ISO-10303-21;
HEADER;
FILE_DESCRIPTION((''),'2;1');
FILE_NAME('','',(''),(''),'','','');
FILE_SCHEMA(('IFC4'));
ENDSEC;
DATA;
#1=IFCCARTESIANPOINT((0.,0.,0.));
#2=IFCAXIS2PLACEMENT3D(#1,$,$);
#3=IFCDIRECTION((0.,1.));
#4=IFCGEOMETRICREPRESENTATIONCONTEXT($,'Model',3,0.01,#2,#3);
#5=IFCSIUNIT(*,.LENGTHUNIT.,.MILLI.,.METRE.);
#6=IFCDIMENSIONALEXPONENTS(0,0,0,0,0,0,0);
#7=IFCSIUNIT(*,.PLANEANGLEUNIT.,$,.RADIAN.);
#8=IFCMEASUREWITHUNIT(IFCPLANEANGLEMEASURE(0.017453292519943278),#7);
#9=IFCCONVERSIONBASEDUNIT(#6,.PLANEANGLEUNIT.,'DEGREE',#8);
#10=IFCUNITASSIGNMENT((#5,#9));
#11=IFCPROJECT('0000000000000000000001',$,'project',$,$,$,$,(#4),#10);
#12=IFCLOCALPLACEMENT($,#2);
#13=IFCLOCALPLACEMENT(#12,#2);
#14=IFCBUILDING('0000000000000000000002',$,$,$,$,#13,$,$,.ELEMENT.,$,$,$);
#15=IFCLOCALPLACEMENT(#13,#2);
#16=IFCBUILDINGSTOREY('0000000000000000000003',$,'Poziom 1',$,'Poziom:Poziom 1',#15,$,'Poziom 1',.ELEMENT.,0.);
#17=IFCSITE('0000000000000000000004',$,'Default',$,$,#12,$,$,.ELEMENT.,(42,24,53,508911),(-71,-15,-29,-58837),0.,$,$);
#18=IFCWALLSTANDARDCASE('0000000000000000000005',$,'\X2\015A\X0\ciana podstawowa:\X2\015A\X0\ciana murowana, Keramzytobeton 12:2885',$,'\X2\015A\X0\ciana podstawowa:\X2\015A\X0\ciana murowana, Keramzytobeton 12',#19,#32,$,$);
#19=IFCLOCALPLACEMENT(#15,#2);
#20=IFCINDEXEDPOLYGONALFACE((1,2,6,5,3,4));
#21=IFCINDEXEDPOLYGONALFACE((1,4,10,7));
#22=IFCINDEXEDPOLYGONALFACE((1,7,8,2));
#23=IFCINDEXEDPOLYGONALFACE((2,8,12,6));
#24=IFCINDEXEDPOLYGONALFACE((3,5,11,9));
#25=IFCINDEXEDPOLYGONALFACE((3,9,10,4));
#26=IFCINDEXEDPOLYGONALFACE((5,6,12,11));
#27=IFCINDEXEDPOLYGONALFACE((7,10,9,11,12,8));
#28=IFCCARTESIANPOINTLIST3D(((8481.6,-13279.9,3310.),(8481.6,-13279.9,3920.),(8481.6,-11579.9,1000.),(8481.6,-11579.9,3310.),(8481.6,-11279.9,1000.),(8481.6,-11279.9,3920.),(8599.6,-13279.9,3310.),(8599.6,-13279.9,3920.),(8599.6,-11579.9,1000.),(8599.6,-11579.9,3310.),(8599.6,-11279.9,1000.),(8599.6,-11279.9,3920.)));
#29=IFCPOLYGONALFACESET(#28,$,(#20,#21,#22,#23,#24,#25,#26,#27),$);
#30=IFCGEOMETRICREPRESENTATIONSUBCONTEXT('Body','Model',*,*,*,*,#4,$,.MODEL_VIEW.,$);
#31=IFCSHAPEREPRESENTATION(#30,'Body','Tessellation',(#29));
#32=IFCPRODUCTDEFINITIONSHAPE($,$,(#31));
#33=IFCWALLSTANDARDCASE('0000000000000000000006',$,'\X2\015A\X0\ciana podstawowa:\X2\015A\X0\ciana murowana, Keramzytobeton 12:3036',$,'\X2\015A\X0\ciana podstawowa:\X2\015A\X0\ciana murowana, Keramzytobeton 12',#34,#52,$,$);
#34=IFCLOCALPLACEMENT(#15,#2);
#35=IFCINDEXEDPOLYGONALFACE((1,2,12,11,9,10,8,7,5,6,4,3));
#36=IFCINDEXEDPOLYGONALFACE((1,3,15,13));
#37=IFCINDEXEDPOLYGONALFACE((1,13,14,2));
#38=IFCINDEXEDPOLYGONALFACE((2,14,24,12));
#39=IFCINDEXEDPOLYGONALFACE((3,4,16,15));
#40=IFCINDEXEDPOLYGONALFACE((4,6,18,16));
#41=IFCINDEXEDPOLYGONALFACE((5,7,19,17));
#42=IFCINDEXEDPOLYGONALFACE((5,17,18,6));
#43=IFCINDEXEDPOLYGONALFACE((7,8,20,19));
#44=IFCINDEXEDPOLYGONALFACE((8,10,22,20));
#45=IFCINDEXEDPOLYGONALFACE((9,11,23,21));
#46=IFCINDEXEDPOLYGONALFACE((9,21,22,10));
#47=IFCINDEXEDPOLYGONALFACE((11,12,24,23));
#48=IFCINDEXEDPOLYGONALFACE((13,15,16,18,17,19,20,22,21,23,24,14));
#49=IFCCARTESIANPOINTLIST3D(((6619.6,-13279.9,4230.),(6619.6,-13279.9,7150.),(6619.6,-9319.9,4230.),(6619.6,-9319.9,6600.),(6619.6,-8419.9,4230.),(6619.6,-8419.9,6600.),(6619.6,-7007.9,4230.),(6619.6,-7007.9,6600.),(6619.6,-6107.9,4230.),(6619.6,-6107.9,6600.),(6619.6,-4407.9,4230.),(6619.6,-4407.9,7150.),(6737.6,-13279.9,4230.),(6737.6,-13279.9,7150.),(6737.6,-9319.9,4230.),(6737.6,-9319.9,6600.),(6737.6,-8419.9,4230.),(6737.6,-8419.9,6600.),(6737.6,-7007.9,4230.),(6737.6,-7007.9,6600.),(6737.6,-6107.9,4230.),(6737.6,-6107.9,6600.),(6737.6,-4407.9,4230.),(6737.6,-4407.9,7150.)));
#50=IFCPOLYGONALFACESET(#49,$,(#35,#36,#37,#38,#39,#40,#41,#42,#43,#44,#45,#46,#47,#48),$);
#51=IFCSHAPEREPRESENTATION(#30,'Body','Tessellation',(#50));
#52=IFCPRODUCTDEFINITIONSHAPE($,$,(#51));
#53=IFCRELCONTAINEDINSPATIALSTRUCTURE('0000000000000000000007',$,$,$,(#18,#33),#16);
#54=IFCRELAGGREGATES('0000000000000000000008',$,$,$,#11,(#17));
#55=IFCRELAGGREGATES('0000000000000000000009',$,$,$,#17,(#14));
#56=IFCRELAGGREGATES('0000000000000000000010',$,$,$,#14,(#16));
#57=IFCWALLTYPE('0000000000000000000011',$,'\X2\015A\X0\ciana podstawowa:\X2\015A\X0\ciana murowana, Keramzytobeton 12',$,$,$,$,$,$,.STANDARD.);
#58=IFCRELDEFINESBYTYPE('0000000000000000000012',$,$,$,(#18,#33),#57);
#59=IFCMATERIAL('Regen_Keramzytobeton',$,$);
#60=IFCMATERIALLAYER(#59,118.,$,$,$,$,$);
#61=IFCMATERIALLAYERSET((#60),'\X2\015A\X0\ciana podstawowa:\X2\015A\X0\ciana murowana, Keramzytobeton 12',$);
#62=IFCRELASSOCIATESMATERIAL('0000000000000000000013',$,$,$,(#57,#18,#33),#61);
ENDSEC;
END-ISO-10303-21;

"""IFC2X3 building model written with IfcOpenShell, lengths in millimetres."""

from ifc_helpers import new_model, entity, si_unit, converted_unit, direction, frame, frame_2d, origin, origin_2d_with_axis, place, context, subcontext, project, spatial, rectangle, extrude, material, layer, layer_set, layer_usage, type_object, element, save


model = new_model("IFC2X3")

# Units and contexts
model_context = context("Model", 3, precision=0.01, world=origin(), true_north=direction((0.0, 1.0)))
body_context = subcontext(model_context, "Body", "Model", "MODEL_VIEW")
ifc_project = project(units=[si_unit("LENGTHUNIT", "METRE", prefix="MILLI"), converted_unit("PLANEANGLEUNIT", "DEGREE", entity("IfcPlaneAngleMeasure", 0.017453292519943278), si_unit("PLANEANGLEUNIT", "RADIAN"), dimensions=[0, 0, 0, 0, 0, 0, 0])], contexts=[model_context])

# Site, building, storey
site_placement = place(None, origin())
site = spatial("IfcSite", under=ifc_project, at=site_placement, Name="Default", CompositionType="ELEMENT", RefLatitude=(42, 24, 53, 508911), RefLongitude=(-71, -15, -29, -58837), RefElevation=0.0)
building_placement = place(site_placement, origin())
building = spatial("IfcBuilding", under=site, at=building_placement, CompositionType="ELEMENT")
storey_placement = place(building_placement, origin())
storey = spatial("IfcBuildingStorey", under=building, at=storey_placement, Name="Poziom 1", ObjectType="Poziom:Poziom 1", LongName="Poziom 1", CompositionType="ELEMENT", Elevation=0.0)

# Shared definitions
ifc_material_1 = material(Name="Regen_Keramzytobeton")

# Wall, opening
ifc_layer_1 = layer(ifc_material_1, 118.0)
ifc_layer_set_1 = layer_set([ifc_layer_1], Name="Ściana podstawowa:Ściana murowana, Keramzytobeton 12")
ifc_layer_usage_1 = layer_usage(ifc_layer_set_1, "AXIS2", "NEGATIVE", 59.0)
wall_type_1 = type_object("IfcWallType", Name="Ściana podstawowa:Ściana murowana, Keramzytobeton 12", PredefinedType="STANDARD", material=ifc_layer_set_1)
wall_1_placement = place(storey_placement, frame((8540.6, -13279.9, 1000.0), z_axis=(0.0, 0.0, 1.0), x_axis=(0.0, 1.0, 0.0)))
wall_1 = element("IfcWallStandardCase", 1, at=wall_1_placement, inside=storey, type_object=wall_type_1, material=ifc_layer_usage_1, Name="Ściana podstawowa:Ściana murowana, Keramzytobeton 12:2885", ObjectType="Ściana podstawowa:Ściana murowana, Keramzytobeton 12", context=body_context, shape_type="SweptSolid", body=[
    extrude(rectangle(XDim=2000.0, YDim=118.0, at=frame_2d((1000.0, 0.0), x_axis=(-1.0, 0.0))), origin(), (0.0, 0.0, 1.0), 2920.0),
])
opening_1_placement = place(wall_1_placement, frame((13279.9, 8540.6, -1000.0), z_axis=(0.0, 0.0, 1.0), x_axis=(0.0, -1.0, 0.0)))
element("IfcOpeningElement", 2, at=opening_1_placement, cuts=wall_1, ObjectType="Opening", context=body_context, shape_type="SweptSolid", body=[
    extrude(rectangle(XDim=2310.0, YDim=1700.0, at=frame_2d((0.0, 0.0), x_axis=(0.0, 1.0))), frame((10123.6, -12429.9, 2155.0), z_axis=(-1.0, 0.0, 0.0), x_axis=(0.0, 1.0, 0.0)), (0.0, 0.0, 1.0), 3048.0),
])

# Wall, openings
ifc_layer_usage_2 = layer_usage(ifc_layer_set_1, "AXIS2", "NEGATIVE", 59.0)
wall_2_placement = place(storey_placement, frame((6678.6, -13279.9, 4230.0), z_axis=(0.0, 0.0, 1.0), x_axis=(0.0, 1.0, 0.0)))
wall_2 = element("IfcWallStandardCase", 3, at=wall_2_placement, inside=storey, type_object=wall_type_1, material=ifc_layer_usage_2, Name="Ściana podstawowa:Ściana murowana, Keramzytobeton 12:3036", ObjectType="Ściana podstawowa:Ściana murowana, Keramzytobeton 12", context=body_context, shape_type="SweptSolid", body=[
    extrude(rectangle(XDim=8872.0, YDim=118.0, at=frame_2d((4436.0, 0.0), x_axis=(1.0, 0.0))), origin(), (0.0, 0.0, 1.0), 2920.0),
])
opening_2_placement = place(wall_2_placement, frame((13279.9, 6678.6, -4230.0), z_axis=(0.0, 0.0, 1.0), x_axis=(0.0, -1.0, 0.0)))
element("IfcOpeningElement", 4, at=opening_2_placement, cuts=wall_2, ObjectType="Opening", context=body_context, shape_type="SweptSolid", body=[
    extrude(rectangle(XDim=2370.0, YDim=900.0, at=origin_2d_with_axis()), frame((8143.6, -8869.9, 5415.0), z_axis=(-1.0, 0.0, 0.0), x_axis=(0.0, 0.0, -1.0)), (0.0, 0.0, 1.0), 3048.0),
])
opening_3_placement = place(wall_2_placement, frame((13279.9, 6678.6, -4230.0), z_axis=(0.0, 0.0, 1.0), x_axis=(0.0, -1.0, 0.0)))
element("IfcOpeningElement", 5, at=opening_3_placement, cuts=wall_2, ObjectType="Opening", context=body_context, shape_type="SweptSolid", body=[
    extrude(rectangle(XDim=2370.0, YDim=900.0, at=origin_2d_with_axis()), frame((8143.6, -6557.9, 5415.0), z_axis=(-1.0, 0.0, 0.0), x_axis=(0.0, 0.0, -1.0)), (0.0, 0.0, 1.0), 3048.0),
])

save(model, "model.ifc")
